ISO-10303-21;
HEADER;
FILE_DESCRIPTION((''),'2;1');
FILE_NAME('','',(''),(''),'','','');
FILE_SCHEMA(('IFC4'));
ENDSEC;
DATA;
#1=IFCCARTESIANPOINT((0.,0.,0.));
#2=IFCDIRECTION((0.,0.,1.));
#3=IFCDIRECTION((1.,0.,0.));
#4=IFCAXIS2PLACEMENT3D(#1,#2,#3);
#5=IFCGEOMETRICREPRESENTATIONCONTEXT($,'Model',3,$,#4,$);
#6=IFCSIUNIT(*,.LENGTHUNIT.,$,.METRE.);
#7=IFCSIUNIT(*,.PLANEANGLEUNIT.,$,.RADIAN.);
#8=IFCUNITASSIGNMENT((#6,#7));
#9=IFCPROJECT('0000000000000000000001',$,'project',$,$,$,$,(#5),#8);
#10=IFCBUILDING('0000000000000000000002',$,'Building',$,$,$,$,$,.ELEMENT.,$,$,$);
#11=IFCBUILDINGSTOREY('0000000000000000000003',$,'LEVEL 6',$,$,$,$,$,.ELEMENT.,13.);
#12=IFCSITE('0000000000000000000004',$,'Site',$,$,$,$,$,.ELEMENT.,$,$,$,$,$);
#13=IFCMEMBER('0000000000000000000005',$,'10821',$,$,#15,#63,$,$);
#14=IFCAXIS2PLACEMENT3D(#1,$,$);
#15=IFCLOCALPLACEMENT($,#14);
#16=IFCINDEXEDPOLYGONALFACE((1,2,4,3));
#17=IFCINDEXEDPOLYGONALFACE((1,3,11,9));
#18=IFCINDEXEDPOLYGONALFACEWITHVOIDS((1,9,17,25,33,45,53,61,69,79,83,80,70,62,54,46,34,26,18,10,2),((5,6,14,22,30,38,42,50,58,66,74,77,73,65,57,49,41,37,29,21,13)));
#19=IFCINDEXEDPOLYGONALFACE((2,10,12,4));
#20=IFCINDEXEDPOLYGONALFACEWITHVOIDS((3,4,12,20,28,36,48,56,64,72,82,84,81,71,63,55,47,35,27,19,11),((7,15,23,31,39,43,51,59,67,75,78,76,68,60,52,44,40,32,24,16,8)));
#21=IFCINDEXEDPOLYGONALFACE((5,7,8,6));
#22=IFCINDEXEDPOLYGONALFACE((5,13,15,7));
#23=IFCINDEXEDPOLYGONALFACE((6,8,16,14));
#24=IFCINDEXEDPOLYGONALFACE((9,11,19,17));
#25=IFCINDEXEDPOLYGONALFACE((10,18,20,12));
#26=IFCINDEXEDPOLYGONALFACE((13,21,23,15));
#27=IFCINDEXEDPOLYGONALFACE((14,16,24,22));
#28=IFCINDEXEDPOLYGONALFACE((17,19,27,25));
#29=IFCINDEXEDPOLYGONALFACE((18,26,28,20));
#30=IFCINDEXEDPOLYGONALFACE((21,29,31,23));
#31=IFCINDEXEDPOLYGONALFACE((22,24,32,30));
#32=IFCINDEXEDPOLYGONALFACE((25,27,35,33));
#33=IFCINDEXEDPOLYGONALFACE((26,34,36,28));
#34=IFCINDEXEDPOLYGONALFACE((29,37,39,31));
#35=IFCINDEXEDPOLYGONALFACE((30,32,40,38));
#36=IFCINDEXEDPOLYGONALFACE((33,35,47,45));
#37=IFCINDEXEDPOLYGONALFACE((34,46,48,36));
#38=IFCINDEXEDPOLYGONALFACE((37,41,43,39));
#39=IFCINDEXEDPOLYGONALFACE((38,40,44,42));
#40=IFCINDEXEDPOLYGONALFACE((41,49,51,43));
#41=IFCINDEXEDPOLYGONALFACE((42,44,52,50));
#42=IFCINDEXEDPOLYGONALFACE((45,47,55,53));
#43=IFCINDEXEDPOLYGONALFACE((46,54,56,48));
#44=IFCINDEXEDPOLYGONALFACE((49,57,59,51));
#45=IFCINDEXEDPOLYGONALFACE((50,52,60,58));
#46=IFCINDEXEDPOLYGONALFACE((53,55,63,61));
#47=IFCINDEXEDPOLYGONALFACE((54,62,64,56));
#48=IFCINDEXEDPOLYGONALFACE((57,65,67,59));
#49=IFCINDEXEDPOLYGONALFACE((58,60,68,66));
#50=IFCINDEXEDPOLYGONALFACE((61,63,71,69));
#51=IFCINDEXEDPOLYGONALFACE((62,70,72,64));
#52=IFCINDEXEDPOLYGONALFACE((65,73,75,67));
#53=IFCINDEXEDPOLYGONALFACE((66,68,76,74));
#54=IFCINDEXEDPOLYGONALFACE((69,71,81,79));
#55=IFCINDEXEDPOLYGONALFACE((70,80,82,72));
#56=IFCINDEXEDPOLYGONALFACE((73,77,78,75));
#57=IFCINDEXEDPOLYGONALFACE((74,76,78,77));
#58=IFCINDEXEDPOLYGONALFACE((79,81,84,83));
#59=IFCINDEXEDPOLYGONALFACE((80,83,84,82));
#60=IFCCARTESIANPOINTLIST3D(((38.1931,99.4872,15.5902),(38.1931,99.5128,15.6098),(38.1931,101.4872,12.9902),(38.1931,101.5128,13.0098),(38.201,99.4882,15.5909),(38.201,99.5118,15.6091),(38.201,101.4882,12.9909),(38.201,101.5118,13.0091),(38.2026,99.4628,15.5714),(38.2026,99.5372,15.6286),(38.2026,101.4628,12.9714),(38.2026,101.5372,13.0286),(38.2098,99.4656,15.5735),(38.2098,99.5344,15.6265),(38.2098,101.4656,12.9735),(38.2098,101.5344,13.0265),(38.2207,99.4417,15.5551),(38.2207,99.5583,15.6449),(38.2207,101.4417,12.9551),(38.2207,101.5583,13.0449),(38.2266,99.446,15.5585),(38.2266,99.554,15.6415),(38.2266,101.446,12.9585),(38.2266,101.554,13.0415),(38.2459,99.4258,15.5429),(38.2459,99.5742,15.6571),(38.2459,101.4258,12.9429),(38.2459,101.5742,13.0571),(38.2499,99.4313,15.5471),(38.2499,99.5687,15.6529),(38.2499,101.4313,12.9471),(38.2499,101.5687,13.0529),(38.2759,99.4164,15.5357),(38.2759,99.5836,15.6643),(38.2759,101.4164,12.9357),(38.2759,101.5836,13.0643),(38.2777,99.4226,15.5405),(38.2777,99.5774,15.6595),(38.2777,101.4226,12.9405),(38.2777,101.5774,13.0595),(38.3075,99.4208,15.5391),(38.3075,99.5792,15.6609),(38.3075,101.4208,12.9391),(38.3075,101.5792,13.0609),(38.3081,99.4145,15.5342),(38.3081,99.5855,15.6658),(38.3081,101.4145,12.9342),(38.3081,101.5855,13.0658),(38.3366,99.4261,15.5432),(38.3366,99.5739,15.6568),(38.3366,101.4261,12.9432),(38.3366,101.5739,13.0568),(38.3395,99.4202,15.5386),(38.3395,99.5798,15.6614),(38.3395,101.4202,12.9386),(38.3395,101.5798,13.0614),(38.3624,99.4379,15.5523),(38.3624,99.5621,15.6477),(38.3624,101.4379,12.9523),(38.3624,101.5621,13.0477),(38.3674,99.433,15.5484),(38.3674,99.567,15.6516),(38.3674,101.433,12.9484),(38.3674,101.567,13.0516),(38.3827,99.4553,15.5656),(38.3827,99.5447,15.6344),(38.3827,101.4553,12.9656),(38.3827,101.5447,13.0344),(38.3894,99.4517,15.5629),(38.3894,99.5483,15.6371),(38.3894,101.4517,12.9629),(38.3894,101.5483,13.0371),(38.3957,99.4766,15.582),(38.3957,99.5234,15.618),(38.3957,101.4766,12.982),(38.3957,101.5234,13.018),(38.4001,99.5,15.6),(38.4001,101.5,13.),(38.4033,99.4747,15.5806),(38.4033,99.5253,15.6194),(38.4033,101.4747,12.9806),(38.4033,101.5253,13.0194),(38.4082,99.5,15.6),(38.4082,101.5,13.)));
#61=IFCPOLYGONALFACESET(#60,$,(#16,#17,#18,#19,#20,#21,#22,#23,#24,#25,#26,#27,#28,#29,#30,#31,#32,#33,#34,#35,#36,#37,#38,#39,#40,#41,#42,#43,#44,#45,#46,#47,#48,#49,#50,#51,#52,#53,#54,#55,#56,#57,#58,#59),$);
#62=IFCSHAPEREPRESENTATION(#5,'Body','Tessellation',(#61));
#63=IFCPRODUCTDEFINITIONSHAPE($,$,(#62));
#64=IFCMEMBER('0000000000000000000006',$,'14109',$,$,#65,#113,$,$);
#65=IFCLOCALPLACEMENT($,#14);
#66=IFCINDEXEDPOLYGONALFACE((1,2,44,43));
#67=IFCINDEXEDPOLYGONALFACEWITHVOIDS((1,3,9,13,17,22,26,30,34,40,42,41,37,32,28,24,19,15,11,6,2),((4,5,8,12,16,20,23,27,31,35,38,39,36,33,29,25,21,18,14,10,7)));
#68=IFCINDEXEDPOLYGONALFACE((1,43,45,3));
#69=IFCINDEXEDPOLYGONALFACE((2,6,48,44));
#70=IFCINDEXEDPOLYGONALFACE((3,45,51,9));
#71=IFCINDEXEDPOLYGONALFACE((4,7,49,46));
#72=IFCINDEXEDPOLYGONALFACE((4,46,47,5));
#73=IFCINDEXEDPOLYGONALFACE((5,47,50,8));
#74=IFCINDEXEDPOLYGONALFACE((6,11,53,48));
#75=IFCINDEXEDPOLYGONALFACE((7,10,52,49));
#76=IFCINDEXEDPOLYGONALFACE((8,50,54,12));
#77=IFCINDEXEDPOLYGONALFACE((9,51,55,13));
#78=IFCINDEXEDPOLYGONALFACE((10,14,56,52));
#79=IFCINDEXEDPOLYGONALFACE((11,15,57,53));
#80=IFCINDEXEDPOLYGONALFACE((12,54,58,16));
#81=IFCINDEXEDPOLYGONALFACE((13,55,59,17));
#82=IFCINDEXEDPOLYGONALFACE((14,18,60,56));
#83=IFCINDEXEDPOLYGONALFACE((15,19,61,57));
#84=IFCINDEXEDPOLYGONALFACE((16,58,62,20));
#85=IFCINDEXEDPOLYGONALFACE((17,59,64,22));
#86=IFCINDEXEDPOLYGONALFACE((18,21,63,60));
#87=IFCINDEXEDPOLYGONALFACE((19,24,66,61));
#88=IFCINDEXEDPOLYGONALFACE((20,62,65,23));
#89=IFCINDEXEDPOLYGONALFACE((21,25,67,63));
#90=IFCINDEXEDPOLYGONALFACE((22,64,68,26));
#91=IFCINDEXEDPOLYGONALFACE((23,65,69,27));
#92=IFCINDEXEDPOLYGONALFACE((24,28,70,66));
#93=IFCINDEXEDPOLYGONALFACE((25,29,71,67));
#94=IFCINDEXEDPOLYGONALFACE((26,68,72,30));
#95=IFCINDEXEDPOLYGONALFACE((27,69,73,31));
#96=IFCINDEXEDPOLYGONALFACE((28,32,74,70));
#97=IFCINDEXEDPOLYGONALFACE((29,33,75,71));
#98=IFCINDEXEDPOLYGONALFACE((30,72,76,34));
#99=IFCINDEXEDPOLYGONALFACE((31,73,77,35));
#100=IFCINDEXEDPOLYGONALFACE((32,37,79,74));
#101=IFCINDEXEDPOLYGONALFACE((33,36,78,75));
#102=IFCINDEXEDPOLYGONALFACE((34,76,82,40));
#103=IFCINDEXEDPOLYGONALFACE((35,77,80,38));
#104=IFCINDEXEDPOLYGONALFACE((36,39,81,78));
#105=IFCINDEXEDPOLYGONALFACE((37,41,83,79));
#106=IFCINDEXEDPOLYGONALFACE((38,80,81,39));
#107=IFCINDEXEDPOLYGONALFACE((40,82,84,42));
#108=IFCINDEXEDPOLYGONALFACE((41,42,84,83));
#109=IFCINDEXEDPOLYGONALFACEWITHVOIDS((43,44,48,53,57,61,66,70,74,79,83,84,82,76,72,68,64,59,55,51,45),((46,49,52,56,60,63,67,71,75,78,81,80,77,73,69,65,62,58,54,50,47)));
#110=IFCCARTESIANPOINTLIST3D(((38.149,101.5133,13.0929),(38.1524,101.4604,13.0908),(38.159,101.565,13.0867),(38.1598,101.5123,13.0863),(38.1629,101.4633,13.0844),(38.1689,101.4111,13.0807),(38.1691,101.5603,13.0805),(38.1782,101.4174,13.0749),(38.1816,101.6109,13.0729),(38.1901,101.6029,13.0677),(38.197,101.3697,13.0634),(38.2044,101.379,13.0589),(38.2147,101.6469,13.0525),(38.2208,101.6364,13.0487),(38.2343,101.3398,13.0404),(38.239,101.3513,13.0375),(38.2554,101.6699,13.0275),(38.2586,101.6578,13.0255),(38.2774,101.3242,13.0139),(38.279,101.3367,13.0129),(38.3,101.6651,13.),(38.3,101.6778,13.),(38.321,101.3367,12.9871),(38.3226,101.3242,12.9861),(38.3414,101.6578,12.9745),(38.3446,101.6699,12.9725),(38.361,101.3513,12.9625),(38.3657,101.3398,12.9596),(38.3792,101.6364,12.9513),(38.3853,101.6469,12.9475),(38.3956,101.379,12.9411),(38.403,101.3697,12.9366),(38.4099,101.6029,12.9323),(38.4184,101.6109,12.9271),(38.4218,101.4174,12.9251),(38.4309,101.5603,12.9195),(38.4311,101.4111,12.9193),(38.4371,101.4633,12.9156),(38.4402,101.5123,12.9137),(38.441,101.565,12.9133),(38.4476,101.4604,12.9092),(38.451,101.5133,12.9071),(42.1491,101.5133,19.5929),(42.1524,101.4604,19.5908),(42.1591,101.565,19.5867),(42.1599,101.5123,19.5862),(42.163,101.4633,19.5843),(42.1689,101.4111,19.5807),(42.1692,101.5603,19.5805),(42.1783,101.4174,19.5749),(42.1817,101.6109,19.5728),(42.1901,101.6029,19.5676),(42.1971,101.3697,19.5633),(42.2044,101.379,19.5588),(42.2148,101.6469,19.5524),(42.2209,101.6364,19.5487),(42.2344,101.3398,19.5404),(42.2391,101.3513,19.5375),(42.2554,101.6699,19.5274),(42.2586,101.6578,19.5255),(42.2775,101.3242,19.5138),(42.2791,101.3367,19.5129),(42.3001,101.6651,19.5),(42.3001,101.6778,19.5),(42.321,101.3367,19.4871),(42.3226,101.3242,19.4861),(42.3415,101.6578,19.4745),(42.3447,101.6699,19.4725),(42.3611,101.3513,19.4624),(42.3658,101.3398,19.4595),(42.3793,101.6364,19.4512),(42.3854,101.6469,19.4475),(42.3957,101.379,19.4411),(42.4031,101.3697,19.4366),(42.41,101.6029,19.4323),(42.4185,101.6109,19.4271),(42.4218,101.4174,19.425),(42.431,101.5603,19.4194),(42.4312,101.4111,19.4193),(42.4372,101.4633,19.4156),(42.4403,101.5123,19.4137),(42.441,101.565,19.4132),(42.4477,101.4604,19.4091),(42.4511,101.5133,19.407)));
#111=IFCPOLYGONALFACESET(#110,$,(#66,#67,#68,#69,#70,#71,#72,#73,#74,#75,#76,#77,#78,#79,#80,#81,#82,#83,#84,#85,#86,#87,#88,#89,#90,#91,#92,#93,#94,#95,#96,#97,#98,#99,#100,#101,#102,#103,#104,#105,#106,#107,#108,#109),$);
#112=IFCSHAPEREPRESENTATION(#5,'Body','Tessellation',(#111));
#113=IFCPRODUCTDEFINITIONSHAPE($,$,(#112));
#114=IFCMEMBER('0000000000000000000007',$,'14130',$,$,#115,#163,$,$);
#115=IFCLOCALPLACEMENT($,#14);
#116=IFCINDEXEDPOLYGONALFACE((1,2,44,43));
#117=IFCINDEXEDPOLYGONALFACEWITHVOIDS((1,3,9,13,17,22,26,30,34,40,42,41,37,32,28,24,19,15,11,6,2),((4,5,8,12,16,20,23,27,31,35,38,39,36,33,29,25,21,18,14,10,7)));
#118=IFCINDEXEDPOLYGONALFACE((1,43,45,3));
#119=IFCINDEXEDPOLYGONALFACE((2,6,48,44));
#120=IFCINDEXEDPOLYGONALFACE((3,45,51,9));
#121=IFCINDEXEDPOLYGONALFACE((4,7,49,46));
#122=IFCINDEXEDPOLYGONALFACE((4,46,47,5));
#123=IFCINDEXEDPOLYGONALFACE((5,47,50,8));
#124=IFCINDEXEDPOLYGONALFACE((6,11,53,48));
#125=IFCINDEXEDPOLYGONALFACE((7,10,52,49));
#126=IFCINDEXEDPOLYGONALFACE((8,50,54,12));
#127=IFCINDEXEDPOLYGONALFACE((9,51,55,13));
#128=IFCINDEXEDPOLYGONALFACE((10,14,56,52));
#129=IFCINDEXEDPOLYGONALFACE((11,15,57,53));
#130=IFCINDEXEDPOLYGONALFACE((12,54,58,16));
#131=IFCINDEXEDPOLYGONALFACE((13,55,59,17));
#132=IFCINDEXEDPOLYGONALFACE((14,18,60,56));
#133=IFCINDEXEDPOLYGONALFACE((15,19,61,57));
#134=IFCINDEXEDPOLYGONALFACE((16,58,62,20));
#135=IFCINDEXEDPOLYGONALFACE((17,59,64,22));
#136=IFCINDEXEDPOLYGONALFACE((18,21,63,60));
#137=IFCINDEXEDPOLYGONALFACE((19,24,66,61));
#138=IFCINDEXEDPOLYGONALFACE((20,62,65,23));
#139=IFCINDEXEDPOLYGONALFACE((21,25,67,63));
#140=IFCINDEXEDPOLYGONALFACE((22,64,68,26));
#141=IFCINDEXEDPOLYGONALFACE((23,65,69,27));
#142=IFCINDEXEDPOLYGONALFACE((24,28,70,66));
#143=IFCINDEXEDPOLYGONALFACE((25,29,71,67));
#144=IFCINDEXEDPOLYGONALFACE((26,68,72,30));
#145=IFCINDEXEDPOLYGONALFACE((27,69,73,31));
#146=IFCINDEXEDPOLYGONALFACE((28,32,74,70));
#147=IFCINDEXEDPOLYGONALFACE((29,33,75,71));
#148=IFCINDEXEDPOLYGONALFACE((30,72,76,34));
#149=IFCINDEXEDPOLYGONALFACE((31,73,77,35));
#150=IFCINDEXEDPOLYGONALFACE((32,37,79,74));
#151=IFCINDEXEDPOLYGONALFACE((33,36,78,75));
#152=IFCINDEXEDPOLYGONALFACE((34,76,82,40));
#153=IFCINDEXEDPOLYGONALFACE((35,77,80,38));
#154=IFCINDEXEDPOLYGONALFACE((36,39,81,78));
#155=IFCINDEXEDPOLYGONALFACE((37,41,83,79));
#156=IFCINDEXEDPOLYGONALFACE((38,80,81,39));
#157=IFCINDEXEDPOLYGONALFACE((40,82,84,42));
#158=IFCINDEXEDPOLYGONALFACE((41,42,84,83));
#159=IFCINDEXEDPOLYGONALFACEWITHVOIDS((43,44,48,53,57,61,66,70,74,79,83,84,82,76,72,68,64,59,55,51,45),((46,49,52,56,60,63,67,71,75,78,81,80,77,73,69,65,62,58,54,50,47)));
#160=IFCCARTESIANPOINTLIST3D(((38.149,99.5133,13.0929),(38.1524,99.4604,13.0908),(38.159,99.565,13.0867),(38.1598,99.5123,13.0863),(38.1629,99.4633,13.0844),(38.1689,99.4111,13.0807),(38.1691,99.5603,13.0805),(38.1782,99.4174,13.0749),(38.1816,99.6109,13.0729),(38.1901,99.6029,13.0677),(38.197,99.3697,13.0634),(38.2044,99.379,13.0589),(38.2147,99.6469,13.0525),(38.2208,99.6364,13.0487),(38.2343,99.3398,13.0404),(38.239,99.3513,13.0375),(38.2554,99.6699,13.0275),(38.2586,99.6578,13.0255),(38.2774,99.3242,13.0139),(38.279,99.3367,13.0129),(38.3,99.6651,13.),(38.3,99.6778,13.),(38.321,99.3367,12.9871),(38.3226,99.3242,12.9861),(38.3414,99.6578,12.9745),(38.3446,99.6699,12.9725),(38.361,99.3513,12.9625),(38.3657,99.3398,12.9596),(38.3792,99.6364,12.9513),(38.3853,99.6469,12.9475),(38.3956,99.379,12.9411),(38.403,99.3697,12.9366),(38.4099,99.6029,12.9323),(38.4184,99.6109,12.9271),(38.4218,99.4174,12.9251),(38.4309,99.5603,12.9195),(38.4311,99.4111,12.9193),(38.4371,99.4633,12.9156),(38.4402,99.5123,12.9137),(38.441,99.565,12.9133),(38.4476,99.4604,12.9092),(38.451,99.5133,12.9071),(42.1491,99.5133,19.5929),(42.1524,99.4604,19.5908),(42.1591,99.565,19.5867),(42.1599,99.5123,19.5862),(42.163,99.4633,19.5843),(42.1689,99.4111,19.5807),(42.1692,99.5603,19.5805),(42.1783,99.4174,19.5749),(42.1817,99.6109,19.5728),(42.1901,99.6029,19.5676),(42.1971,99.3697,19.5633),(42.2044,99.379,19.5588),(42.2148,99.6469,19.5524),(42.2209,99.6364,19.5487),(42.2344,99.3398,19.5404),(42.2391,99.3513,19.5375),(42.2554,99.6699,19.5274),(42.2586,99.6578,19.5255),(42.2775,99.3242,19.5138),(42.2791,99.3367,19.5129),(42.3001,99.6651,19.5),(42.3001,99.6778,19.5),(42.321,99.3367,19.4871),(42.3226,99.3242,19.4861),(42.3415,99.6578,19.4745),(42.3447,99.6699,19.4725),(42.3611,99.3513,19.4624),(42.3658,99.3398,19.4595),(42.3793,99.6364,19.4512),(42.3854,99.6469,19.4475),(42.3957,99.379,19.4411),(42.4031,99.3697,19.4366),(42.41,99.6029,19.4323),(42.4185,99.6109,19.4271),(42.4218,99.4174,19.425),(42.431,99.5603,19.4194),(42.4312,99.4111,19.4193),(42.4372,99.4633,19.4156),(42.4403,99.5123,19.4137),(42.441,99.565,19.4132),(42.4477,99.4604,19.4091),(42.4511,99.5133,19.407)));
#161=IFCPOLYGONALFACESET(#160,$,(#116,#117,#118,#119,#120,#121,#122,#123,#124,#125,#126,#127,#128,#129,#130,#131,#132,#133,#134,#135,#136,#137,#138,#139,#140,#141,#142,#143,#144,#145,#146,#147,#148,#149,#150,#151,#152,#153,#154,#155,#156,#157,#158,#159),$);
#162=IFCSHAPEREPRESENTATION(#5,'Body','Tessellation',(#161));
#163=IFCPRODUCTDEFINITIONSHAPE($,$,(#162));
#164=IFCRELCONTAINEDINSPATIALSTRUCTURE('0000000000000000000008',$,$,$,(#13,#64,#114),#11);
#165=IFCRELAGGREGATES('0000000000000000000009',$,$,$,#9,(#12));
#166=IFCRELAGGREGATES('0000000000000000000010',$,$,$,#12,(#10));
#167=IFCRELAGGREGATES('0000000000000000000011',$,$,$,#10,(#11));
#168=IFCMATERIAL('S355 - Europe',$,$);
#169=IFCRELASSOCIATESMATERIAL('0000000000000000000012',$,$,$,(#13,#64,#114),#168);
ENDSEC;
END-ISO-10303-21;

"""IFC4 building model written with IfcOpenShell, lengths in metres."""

from ifc_helpers import new_model, si_unit, frame, origin_with_axes, origin_2d_with_axis, place, context, project, spatial, hollow_circle, extrude, material, material_profile, profile_set, profile_usage, element, save


model = new_model("IFC4")

# Units and contexts
model_context = context("Model", 3, world=origin_with_axes())
ifc_project = project(units=[si_unit("LENGTHUNIT", "METRE"), si_unit("PLANEANGLEUNIT", "RADIAN")], contexts=[model_context])

# Site, building, storey
site = spatial("IfcSite", under=ifc_project, Name="Site", CompositionType="ELEMENT")
building = spatial("IfcBuilding", under=site, Name="Building", CompositionType="ELEMENT")
storey = spatial("IfcBuildingStorey", under=building, Name="LEVEL 6", CompositionType="ELEMENT", Elevation=13.0)

# Shared definitions
ifc_material = material(Name="S355 - Europe")

# Members
ifc_material_profile_1 = material_profile(ifc_material, hollow_circle(Radius=0.1081, WallThickness=0.008, at=origin_2d_with_axis()))
ifc_profile_set_1 = profile_set([ifc_material_profile_1])
ifc_profile_usage_1 = profile_usage(ifc_profile_set_1, cardinal=10)
member_1_placement = place(None, frame((38.3, 101.5, 13.0), z_axis=(0.0, -0.609711, 0.792624), x_axis=(1.0, 0.0, 0.0)))
element("IfcMember", 1, at=member_1_placement, inside=storey, material=ifc_profile_usage_1, Name="10821", context=model_context, shape_type="SweptSolid", body=[
    extrude(hollow_circle(Radius=0.1081, WallThickness=0.008, at=origin_2d_with_axis()), origin_with_axes(), (0.0, 0.0, 1.0), 3.2802),
])
ifc_material_profile_2 = material_profile(ifc_material, hollow_circle(Radius=0.1778, WallThickness=0.0127, at=origin_2d_with_axis()))
ifc_profile_set_2 = profile_set([ifc_material_profile_2])
ifc_profile_usage_2 = profile_usage(ifc_profile_set_2, cardinal=10)
member_2_placement = place(None, frame((38.3, 101.5, 13.0), z_axis=(0.524107, 0.0, 0.851652), x_axis=(0.0, 1.0, 0.0)))
element("IfcMember", 2, at=member_2_placement, inside=storey, material=ifc_profile_usage_2, Name="14109", context=model_context, shape_type="SweptSolid", body=[
    extrude(hollow_circle(Radius=0.1778, WallThickness=0.0127, at=origin_2d_with_axis()), origin_with_axes(), (0.0, 0.0, 1.0), 7.6322),
])
ifc_material_profile_3 = material_profile(ifc_material, hollow_circle(Radius=0.1778, WallThickness=0.0127, at=origin_2d_with_axis()))
ifc_profile_set_3 = profile_set([ifc_material_profile_3])
ifc_profile_usage_3 = profile_usage(ifc_profile_set_3, cardinal=10)
member_3_placement = place(None, frame((38.3, 99.5, 13.0), z_axis=(0.524107, 0.0, 0.851652), x_axis=(0.0, 1.0, 0.0)))
element("IfcMember", 3, at=member_3_placement, inside=storey, material=ifc_profile_usage_3, Name="14130", context=model_context, shape_type="SweptSolid", body=[
    extrude(hollow_circle(Radius=0.1778, WallThickness=0.0127, at=origin_2d_with_axis()), origin_with_axes(), (0.0, 0.0, 1.0), 7.6322),
])

save(model, "model.ifc")
